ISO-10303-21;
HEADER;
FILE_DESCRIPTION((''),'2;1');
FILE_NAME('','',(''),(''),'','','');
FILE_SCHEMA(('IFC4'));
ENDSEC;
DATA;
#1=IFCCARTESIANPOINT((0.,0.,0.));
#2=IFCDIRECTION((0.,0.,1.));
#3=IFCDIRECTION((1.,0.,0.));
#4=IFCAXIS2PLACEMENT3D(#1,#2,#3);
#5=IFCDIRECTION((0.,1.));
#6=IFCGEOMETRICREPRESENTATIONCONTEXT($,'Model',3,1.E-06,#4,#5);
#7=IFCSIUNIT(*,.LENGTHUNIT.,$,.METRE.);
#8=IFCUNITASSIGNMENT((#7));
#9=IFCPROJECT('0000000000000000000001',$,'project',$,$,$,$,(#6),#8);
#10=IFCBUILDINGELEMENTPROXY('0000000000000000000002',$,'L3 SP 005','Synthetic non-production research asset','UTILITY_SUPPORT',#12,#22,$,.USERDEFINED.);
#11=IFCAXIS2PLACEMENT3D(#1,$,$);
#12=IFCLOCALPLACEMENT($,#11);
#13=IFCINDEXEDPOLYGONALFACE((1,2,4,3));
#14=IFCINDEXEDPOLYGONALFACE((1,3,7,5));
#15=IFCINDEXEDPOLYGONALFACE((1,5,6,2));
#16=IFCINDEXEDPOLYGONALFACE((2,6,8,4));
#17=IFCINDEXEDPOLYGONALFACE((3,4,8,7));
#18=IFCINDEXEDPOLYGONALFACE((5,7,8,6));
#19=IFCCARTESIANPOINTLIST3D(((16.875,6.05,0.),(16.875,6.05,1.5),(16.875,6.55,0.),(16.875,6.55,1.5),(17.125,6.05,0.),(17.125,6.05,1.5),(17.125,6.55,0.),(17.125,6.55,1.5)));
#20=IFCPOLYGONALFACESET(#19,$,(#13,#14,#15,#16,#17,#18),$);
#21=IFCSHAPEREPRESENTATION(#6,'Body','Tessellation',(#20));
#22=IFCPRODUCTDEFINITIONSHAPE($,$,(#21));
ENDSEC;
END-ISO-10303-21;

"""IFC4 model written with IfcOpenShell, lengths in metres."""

from ifc_helpers import new_model, si_unit, direction, frame, origin_with_axes, origin_2d_with_axis, place, context, project, rectangle, extrude, element, save


model = new_model("IFC4")

# Units and contexts
model_context = context("Model", 3, precision=1e-06, world=origin_with_axes(), true_north=direction((0.0, 1.0)))
ifc_project = project(units=[si_unit("LENGTHUNIT", "METRE")], contexts=[model_context])

# Building element proxy
proxy_placement = place(None, frame((17.0, 6.3, 0.0), z_axis=(0.0, 0.0, 1.0), x_axis=(1.0, 0.0, 0.0)))
element("IfcBuildingElementProxy", 1, at=proxy_placement, Name="L3 SP 005", Description="Synthetic non-production research asset", ObjectType="UTILITY_SUPPORT", PredefinedType="USERDEFINED", context=model_context, shape_type="SweptSolid", body=[
    extrude(rectangle(XDim=0.25, YDim=0.5, at=origin_2d_with_axis()), origin_with_axes(), (0.0, 0.0, 1.0), 1.5),
])

save(model, "model.ifc")
